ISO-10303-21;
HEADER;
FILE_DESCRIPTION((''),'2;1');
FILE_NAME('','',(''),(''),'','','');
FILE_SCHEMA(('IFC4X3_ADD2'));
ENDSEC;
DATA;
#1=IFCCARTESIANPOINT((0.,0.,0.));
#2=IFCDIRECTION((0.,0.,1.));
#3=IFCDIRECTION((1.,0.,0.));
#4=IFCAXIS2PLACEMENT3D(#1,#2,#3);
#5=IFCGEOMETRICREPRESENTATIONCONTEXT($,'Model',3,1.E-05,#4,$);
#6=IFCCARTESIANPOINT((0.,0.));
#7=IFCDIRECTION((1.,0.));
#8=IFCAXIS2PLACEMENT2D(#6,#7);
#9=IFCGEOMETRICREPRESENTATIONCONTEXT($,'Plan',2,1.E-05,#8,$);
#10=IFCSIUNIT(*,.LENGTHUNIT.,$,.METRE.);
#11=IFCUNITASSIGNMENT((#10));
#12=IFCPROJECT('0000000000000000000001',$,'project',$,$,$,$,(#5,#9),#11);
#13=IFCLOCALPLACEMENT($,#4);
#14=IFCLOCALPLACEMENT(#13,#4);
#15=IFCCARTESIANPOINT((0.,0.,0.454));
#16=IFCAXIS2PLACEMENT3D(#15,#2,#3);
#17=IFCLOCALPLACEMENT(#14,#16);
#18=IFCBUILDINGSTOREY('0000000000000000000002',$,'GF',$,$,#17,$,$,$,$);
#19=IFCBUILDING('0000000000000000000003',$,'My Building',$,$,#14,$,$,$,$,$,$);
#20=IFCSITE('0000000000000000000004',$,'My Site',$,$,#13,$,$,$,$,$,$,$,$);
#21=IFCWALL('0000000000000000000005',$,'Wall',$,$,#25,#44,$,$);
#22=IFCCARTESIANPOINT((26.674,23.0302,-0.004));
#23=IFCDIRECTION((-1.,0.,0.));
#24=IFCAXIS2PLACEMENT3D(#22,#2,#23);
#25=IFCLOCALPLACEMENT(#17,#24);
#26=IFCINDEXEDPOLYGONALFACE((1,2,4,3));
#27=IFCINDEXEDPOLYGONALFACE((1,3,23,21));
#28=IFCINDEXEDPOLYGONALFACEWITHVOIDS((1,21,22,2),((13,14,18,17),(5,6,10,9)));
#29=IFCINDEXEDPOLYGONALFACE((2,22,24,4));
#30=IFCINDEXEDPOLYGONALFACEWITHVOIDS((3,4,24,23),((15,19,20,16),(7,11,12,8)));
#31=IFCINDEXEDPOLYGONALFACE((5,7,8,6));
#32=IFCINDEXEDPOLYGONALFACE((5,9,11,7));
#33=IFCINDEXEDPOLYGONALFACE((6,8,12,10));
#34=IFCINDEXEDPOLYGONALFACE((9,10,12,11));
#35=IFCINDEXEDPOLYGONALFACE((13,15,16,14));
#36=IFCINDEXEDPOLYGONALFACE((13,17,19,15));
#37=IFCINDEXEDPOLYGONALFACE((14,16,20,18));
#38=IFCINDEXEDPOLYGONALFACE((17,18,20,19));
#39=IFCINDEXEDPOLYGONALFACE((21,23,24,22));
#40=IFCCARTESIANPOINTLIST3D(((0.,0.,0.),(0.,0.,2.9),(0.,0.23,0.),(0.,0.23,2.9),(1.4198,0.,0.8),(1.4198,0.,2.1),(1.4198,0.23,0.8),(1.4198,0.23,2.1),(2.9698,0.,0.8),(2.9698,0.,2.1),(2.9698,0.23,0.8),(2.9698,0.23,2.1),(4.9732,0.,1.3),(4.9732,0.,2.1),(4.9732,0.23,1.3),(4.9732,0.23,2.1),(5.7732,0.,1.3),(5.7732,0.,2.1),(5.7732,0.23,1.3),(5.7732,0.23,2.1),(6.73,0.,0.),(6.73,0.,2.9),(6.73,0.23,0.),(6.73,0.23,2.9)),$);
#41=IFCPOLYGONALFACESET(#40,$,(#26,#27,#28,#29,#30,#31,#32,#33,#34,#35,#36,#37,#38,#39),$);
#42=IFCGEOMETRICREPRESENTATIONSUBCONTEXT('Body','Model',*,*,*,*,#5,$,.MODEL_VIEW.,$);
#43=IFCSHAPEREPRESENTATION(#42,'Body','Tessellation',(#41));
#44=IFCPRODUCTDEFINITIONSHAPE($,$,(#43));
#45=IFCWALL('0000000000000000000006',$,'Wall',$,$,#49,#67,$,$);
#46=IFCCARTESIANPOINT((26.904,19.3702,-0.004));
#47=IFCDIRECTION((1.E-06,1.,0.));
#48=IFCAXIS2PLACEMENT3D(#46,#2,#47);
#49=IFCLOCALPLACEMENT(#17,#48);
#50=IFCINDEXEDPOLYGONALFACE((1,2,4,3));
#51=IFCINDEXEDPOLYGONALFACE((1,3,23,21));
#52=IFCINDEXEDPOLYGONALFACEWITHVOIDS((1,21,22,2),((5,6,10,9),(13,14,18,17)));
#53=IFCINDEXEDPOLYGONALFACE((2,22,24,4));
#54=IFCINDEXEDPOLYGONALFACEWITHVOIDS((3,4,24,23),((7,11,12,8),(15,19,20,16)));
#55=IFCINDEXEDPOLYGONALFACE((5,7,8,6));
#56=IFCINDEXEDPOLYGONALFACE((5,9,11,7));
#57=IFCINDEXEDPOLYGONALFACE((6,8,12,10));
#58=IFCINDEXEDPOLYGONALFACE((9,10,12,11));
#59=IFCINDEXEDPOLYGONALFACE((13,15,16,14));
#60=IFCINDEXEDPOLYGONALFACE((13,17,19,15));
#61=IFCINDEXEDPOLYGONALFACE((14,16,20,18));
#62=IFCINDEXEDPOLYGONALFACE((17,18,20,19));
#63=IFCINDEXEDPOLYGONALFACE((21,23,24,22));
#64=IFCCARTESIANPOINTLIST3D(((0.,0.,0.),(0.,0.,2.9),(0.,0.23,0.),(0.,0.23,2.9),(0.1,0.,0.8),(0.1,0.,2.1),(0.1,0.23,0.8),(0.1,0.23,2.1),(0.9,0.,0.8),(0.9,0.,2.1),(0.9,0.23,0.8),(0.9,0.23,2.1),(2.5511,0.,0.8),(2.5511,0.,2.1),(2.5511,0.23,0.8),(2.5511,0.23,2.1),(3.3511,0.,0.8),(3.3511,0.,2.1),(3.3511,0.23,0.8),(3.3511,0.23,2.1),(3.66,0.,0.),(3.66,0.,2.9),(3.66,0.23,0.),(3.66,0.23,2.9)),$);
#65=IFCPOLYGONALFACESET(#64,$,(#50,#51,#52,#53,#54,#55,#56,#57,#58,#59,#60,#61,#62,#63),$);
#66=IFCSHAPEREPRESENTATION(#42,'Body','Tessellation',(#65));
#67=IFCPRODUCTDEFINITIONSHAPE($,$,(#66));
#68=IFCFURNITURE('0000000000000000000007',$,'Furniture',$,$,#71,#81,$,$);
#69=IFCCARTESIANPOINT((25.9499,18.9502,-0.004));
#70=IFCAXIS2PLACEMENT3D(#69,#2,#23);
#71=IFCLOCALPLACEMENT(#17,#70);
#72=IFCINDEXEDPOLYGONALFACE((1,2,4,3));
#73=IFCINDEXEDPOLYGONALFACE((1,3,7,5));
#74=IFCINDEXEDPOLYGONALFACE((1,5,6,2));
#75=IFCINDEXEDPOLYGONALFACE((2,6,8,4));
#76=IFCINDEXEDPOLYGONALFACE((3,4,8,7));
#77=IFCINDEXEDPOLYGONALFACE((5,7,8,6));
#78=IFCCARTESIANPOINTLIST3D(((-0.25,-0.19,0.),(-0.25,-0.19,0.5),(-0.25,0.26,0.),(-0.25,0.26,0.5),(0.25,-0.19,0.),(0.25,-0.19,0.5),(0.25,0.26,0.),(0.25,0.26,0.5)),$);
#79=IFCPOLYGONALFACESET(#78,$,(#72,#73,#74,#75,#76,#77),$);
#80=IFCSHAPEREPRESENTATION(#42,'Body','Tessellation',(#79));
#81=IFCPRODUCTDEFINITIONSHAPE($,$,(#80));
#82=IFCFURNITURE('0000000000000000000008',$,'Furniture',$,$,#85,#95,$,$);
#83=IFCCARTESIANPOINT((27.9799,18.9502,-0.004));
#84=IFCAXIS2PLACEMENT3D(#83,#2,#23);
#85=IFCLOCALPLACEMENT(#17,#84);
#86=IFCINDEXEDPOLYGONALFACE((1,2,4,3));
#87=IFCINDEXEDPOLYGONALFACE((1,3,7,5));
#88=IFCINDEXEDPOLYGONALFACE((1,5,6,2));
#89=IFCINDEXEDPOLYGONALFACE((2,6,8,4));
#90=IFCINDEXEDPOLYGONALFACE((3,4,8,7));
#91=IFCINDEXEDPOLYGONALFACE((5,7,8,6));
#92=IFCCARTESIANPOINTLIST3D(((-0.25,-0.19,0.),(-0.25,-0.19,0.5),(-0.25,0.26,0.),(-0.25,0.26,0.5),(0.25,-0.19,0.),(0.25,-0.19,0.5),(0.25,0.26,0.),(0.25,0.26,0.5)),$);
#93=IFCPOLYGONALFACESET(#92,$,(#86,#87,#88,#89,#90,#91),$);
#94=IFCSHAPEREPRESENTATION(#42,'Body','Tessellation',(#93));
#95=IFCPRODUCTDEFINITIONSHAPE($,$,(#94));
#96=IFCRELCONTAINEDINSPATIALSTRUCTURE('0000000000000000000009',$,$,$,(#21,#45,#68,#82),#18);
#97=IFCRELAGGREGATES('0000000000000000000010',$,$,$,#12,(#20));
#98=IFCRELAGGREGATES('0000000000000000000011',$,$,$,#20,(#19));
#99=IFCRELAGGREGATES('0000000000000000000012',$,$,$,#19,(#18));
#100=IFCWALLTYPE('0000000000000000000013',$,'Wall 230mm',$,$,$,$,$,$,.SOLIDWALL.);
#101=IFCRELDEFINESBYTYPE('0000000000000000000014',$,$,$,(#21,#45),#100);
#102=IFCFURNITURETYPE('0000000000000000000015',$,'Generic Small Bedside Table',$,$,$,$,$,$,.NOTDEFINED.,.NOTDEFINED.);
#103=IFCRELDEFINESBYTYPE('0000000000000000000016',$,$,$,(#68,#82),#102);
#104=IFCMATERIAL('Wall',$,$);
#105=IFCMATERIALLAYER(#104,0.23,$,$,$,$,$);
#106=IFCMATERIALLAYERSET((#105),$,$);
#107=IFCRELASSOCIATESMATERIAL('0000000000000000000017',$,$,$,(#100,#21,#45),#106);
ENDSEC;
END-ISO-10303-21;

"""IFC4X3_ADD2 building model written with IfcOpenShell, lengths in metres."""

from ifc_helpers import new_model, entity, si_unit, frame, origin_with_axes, origin_2d_with_axis, place, context, subcontext, project, spatial, line, indexed_curve, outline, extrude, shape, source, transform, mapped, material, layer, layer_set, layer_usage, type_object, type_shapes, element, save


model = new_model("IFC4X3_ADD2")

# Units and contexts
model_context = context("Model", 3, precision=1e-05, world=origin_with_axes())
plan_context = context("Plan", 2, precision=1e-05, world=origin_2d_with_axis())
body_context_1 = subcontext(model_context, "Body", "Model", "MODEL_VIEW")
body_context_2 = subcontext(plan_context, "Body", "Plan", "PLAN_VIEW")
ifc_project = project(units=[si_unit("LENGTHUNIT", "METRE")], contexts=[model_context, plan_context])

# Site, building, storey
site_placement = place(None, origin_with_axes())
site = spatial("IfcSite", under=ifc_project, at=site_placement, Name="My Site")
building_placement = place(site_placement, origin_with_axes())
building = spatial("IfcBuilding", under=site, at=building_placement, Name="My Building")
storey_placement = place(building_placement, frame((0.0, 0.0, 0.454), z_axis=(0.0, 0.0, 1.0), x_axis=(1.0, 0.0, 0.0)))
storey = spatial("IfcBuildingStorey", under=building, at=storey_placement, Name="GF")

# Walls, openings
ifc_material_1 = material(Name="Wall")
ifc_layer = layer(ifc_material_1, 0.23)
ifc_layer_set = layer_set([ifc_layer])
ifc_layer_usage_1 = layer_usage(ifc_layer_set, "AXIS2", "POSITIVE", 0.0)
wall_type = type_object("IfcWallType", Name="Wall 230mm", PredefinedType="SOLIDWALL", material=ifc_layer_set)
wall_1_placement = place(storey_placement, frame((26.674, 23.0302, -0.004), z_axis=(0.0, 0.0, 1.0), x_axis=(-1.0, 0.0, 0.0)))
wall_1 = element("IfcWall", 1, at=wall_1_placement, inside=storey, type_object=wall_type, material=ifc_layer_usage_1, Name="Wall", context=body_context_1, shape_type="SweptSolid", body=[
    extrude(outline(indexed_curve([(0.0, 0.0), (0.0, 0.23), (6.73, 0.23), (6.73, 0.0), (0.0, 0.0)], self_intersect=False)), origin_with_axes(), (0.0, 0.0, 1.0), 2.9),
])
shared_shape_1 = source(origin_with_axes(), body_context_1, "Body", "SweptSolid", [
    extrude(outline(indexed_curve([(0.0, 0.0), (0.8, 0.0), (0.8, 0.8), (0.0, 0.8)], segments=[line(1, 2, 3, 4, 1)])), frame((-0.4, -0.6, 0.0), z_axis=(0.0, -1.0, 0.0), x_axis=(1.0, 0.0, 0.0)), (0.0, 0.0, -1.0), 1.2),
])
opening_1_placement = place(wall_1_placement, frame((5.3732, 0.16, 1.3), z_axis=(0.0, 0.0, 1.0), x_axis=(1.0, 0.0, 0.0)))
element("IfcOpeningElement", 2, at=opening_1_placement, cuts=wall_1, PredefinedType="OPENING", context=body_context_1, shape_type="MappedRepresentation", body=[
    mapped(shared_shape_1, transform((0.0, 0.0, 0.0), x_axis=(1.0, 0.0, 0.0), y_axis=(0.0, 1.0, 0.0), z_axis=(0.0, 0.0, 1.0), scale=1.0)),
])
shared_shape_2 = source(origin_with_axes(), body_context_1, "Body", "SweptSolid", [
    extrude(outline(indexed_curve([(0.0, 0.0), (1.55, 0.0), (1.55, 1.3), (0.0, 1.3)], segments=[line(1, 2, 3, 4, 1)])), frame((-0.775, -0.6, 0.0), z_axis=(0.0, -1.0, 0.0), x_axis=(1.0, 0.0, 0.0)), (0.0, 0.0, -1.0), 1.2),
])
opening_2_placement = place(wall_1_placement, frame((2.1948, 0.16, 0.8), z_axis=(0.0, 0.0, 1.0), x_axis=(1.0, 0.0, 0.0)))
element("IfcOpeningElement", 3, at=opening_2_placement, cuts=wall_1, PredefinedType="OPENING", context=body_context_1, shape_type="MappedRepresentation", body=[
    mapped(shared_shape_2, transform((0.0, 0.0, 0.0), x_axis=(1.0, 0.0, 0.0), y_axis=(0.0, 1.0, 0.0), z_axis=(0.0, 0.0, 1.0), scale=1.0)),
])
ifc_layer_usage_2 = layer_usage(ifc_layer_set, "AXIS2", "POSITIVE", 0.0)
wall_2_placement = place(storey_placement, frame((26.904, 19.3702, -0.004), z_axis=(0.0, 0.0, 1.0), x_axis=(0.000001, 1.0, 0.0)))
wall_2 = element("IfcWall", 4, at=wall_2_placement, inside=storey, type_object=wall_type, material=ifc_layer_usage_2, Name="Wall", context=body_context_1, shape_type="SweptSolid", body=[
    extrude(outline(indexed_curve([(0.0, 0.0), (0.0, 0.23), (3.66, 0.23), (3.66, 0.0), (0.0, 0.0)], self_intersect=False)), origin_with_axes(), (0.0, 0.0, 1.0), 2.9),
])
shared_shape_3 = source(origin_with_axes(), body_context_1, "Body", "SweptSolid", [
    extrude(outline(indexed_curve([(0.0, 0.0), (0.8, 0.0), (0.8, 1.3), (0.0, 1.3)], segments=[line(1, 2, 3, 4, 1)])), frame((-0.4, -0.6, 0.0), z_axis=(0.0, -1.0, 0.0), x_axis=(1.0, 0.0, 0.0)), (0.0, 0.0, -1.0), 1.2),
])
opening_3_placement = place(wall_2_placement, frame((0.5, 0.16, 0.8), z_axis=(0.0, 0.0, 1.0), x_axis=(1.0, 0.0, 0.0)))
element("IfcOpeningElement", 5, at=opening_3_placement, cuts=wall_2, PredefinedType="OPENING", context=body_context_1, shape_type="MappedRepresentation", body=[
    mapped(shared_shape_3, transform((0.0, 0.0, 0.0), x_axis=(1.0, 0.0, 0.0), y_axis=(0.0, 1.0, 0.0), z_axis=(0.0, 0.0, 1.0), scale=1.0)),
])
opening_4_placement = place(wall_2_placement, frame((2.9511, 0.16, 0.8), z_axis=(0.0, 0.0, 1.0), x_axis=(1.0, 0.0, 0.0)))
element("IfcOpeningElement", 6, at=opening_4_placement, cuts=wall_2, PredefinedType="OPENING", context=body_context_1, shape_type="MappedRepresentation", body=[
    mapped(shared_shape_3, transform((0.0, 0.0, 0.0), x_axis=(1.0, 0.0, 0.0), y_axis=(0.0, 1.0, 0.0), z_axis=(0.0, 0.0, 1.0), scale=1.0)),
])

# Furniture
furniture_type_1 = type_object("IfcFurnitureType", Name="Generic Small Bedside Table", AssemblyPlace="NOTDEFINED", PredefinedType="NOTDEFINED")
shared_shape_4 = source(origin_with_axes(), body_context_1, "Body", "SweptSolid", [
    extrude(outline(indexed_curve([(0.5, 0.45), (0.5, 0.0), (0.0, 0.0), (0.0, 0.45)], segments=[line(4, 1), line(1, 2), line(2, 3), line(3, 4)], self_intersect=False)), frame((-0.25, -0.19, 0.0), z_axis=(0.0, 0.0, 1.0), x_axis=(1.0, 0.0, 0.0)), (0.0, 0.0, 1.0), 0.5),
])
shared_shape_5 = source(origin_with_axes(), body_context_2, "Body", "Annotation2D", [
    entity("IfcGeometricCurveSet", [entity("IfcIndexedPolyCurve", entity("IfcCartesianPointList2D", [[-0.25, -0.19], [0.25, -0.19], [0.25, 0.26], [-0.25, 0.26]]), [entity("IfcLineIndex", [1, 2]), entity("IfcLineIndex", [2, 3]), entity("IfcLineIndex", [3, 4]), entity("IfcLineIndex", [4, 1])])]),
])
type_shapes(furniture_type_1, [shared_shape_4, shared_shape_5])
for number, where, z_axis, x_axis, name in (
    (7, (25.9499, 18.9502, -0.004), (0.0, 0.0, 1.0), (-1.0, 0.0, 0.0), "Furniture"),
    (8, (27.9799, 18.9502, -0.004), (0.0, 0.0, 1.0), (-1.0, 0.0, 0.0), "Furniture"),
):
    element("IfcFurniture", number, at=place(storey_placement, frame(where, z_axis=z_axis, x_axis=x_axis)), inside=storey, type_object=furniture_type_1, Name=name, shapes=[
        shape(body_context_1, "Body", "MappedRepresentation", [mapped(shared_shape_4, transform((0.0, 0.0, 0.0), x_axis=(1.0, 0.0, 0.0), y_axis=(0.0, 1.0, 0.0), z_axis=(0.0, 0.0, 1.0), scale=1.0))]),
        shape(body_context_2, "Body", "MappedRepresentation", [mapped(shared_shape_5, transform((0.0, 0.0, 0.0), x_axis=(1.0, 0.0, 0.0), y_axis=(0.0, 1.0, 0.0), z_axis=(0.0, 0.0, 1.0), scale=1.0))]),
    ])

save(model, "model.ifc")
